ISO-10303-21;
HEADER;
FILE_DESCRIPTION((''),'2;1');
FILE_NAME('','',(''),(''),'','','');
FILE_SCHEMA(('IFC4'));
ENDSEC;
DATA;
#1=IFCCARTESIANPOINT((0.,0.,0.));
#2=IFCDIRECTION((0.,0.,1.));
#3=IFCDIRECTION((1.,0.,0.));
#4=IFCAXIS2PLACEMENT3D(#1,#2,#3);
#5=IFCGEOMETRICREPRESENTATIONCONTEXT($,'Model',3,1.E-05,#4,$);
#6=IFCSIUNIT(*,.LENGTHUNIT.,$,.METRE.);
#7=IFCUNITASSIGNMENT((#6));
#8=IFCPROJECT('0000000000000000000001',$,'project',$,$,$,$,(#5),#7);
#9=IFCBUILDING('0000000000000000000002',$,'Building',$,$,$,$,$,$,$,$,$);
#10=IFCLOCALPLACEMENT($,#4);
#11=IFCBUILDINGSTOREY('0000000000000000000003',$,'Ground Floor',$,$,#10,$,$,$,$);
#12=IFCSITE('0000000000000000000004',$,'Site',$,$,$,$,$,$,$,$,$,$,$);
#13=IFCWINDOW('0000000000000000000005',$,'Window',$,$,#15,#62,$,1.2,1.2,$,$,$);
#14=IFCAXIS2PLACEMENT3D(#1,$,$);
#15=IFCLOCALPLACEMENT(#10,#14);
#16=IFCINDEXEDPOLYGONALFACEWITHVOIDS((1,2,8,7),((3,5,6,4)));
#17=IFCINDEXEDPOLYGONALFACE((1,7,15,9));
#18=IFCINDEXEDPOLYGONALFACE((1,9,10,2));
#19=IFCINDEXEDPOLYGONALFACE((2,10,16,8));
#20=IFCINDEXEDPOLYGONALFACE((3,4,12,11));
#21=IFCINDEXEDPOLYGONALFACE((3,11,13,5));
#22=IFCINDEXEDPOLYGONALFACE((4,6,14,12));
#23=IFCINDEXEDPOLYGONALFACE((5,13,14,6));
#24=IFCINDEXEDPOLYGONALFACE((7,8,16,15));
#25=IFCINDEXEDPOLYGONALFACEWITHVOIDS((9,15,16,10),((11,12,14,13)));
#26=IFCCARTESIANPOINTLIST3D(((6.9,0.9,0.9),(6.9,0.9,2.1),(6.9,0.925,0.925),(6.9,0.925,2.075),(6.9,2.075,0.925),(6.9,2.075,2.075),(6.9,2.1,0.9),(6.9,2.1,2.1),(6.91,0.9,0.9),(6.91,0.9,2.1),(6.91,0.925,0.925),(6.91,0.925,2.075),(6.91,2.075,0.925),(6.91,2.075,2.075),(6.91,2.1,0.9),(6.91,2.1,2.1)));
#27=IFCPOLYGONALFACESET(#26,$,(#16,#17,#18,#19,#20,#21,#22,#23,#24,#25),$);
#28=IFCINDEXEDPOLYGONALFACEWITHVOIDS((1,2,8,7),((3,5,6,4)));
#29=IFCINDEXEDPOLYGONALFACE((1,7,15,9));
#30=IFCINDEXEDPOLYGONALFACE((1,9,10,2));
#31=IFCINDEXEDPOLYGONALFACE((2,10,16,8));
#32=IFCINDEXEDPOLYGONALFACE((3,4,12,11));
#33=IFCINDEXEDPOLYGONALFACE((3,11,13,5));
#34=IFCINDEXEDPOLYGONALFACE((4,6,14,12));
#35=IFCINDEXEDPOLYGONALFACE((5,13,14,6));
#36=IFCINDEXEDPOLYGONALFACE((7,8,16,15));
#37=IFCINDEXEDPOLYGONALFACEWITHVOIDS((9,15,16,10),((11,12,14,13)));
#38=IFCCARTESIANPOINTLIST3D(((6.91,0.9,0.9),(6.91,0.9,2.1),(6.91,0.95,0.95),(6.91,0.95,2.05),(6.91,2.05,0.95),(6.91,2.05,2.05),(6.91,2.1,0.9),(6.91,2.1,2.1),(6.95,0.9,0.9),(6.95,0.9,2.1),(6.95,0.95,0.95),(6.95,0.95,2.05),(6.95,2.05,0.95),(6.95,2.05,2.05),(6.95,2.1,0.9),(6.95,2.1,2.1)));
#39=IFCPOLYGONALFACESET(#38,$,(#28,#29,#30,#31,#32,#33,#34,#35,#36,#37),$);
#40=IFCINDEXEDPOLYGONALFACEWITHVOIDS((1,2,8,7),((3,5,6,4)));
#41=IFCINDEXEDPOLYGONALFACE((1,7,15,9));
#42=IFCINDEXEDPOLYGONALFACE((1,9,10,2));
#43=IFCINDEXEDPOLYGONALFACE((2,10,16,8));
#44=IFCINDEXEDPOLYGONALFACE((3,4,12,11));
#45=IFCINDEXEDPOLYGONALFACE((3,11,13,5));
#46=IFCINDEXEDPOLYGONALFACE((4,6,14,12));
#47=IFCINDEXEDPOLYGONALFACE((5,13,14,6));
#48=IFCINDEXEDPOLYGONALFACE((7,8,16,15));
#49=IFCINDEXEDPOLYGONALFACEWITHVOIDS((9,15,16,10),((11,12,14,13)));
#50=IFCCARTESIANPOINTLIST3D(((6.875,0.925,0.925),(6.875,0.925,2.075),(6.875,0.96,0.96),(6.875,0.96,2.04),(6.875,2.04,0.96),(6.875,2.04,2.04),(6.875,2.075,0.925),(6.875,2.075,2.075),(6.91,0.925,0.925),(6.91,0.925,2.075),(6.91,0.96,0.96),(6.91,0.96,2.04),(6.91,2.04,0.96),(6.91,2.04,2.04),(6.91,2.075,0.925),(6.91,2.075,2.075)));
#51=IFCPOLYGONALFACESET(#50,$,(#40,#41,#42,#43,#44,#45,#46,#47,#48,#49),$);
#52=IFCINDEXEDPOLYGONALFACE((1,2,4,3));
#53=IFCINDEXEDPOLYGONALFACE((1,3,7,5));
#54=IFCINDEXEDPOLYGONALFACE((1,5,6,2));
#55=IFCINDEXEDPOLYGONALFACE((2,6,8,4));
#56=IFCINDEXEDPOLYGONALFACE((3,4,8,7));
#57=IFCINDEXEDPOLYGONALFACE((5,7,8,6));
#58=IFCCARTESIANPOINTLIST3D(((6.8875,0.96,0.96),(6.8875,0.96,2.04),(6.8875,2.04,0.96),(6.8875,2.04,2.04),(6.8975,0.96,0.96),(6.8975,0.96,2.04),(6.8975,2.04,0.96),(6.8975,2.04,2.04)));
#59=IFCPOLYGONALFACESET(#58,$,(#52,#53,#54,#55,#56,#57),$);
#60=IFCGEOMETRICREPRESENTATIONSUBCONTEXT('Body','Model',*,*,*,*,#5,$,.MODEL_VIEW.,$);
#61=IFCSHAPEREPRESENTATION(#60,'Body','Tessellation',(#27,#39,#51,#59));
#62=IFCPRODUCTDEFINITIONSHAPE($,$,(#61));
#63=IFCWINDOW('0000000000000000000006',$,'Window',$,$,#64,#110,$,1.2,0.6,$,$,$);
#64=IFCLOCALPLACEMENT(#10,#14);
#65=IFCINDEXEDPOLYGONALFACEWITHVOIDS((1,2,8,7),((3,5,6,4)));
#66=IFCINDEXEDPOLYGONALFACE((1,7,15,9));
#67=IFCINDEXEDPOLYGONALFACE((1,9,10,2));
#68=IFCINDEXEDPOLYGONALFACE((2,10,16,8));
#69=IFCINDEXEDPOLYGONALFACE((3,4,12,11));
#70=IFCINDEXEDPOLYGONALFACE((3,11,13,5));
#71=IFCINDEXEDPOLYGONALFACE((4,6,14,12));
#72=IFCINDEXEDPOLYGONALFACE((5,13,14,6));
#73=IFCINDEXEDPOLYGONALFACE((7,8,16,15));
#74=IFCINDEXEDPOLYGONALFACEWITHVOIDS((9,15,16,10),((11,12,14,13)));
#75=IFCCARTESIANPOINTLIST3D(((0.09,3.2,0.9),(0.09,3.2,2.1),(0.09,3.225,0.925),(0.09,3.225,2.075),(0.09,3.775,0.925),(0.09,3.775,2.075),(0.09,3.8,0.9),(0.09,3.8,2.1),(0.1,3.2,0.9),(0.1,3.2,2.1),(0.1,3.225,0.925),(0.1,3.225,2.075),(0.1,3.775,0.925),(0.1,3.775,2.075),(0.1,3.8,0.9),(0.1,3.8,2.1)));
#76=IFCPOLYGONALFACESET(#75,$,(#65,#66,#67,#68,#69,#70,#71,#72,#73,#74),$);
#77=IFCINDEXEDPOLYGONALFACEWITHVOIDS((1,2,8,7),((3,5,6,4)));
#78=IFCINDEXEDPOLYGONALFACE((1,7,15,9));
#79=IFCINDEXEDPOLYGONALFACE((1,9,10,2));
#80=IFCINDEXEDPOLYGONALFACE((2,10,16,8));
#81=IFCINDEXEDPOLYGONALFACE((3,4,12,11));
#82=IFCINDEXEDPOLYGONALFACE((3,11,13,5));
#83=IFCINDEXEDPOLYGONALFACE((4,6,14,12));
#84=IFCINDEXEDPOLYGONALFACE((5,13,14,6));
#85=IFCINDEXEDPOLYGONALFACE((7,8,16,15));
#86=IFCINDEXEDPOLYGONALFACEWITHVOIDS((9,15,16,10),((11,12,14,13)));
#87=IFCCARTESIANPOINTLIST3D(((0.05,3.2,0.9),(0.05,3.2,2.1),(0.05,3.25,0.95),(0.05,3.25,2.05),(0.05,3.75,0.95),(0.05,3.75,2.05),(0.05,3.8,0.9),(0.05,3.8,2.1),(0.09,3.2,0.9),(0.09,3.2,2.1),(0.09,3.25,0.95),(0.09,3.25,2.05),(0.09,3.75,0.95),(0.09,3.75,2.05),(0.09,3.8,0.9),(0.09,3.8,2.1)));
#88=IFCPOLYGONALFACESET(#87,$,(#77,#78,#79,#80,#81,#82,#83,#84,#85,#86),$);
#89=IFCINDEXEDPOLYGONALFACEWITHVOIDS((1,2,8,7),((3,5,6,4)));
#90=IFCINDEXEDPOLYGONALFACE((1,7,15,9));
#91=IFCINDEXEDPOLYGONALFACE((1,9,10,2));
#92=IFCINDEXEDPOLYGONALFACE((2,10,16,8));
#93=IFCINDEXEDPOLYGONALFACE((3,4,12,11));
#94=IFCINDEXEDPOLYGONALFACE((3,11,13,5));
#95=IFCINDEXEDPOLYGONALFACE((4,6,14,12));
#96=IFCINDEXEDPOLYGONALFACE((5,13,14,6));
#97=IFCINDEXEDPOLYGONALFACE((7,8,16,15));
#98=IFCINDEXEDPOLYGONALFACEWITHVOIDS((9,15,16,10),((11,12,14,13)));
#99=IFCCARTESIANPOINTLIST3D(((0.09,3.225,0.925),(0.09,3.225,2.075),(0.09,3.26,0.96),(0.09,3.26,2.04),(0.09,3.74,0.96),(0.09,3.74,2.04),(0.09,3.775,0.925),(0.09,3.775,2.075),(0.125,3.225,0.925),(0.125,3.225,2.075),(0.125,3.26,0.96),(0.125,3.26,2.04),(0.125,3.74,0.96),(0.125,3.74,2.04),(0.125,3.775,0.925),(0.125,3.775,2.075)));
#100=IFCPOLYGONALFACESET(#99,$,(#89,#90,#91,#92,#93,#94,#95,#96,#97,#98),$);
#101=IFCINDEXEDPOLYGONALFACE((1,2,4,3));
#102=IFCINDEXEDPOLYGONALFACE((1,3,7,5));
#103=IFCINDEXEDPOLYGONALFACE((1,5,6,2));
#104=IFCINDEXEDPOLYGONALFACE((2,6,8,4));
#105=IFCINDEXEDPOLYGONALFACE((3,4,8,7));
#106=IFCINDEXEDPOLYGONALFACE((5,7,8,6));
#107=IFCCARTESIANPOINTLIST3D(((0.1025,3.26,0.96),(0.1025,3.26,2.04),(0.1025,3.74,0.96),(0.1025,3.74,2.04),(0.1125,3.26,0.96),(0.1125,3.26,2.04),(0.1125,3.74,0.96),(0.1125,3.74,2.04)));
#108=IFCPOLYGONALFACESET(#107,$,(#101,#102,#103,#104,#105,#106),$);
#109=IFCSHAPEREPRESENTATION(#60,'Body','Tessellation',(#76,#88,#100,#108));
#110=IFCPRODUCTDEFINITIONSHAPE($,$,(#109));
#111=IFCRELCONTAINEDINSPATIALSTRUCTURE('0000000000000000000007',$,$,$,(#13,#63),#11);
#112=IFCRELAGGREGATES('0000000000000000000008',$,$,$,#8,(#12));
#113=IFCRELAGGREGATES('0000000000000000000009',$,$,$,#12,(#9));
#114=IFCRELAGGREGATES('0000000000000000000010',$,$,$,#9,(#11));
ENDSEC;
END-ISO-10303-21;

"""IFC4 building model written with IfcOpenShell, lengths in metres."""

from ifc_helpers import new_model, si_unit, frame, origin_with_axes, place, context, subcontext, project, spatial, line, indexed_curve, outline, extrude, element, save


model = new_model("IFC4")

# Units and contexts
model_context = context("Model", 3, precision=1e-05, world=origin_with_axes())
body_context = subcontext(model_context, "Body", "Model", "MODEL_VIEW")
ifc_project = project(units=[si_unit("LENGTHUNIT", "METRE")], contexts=[model_context])

# Site, building, storey
site = spatial("IfcSite", under=ifc_project, Name="Site")
building = spatial("IfcBuilding", under=site, Name="Building")
storey_placement = place(None, origin_with_axes())
storey = spatial("IfcBuildingStorey", under=building, at=storey_placement, Name="Ground Floor")

# Windows
window_1_placement = place(storey_placement, frame((7.0, 0.9, 0.9), z_axis=(0.0, 0.0, 1.0), x_axis=(0.0, 1.0, 0.0)))
element("IfcWindow", 1, at=window_1_placement, inside=storey, Name="Window", OverallHeight=1.2, OverallWidth=1.2, context=body_context, shape_type="SweptSolid", body=[
    extrude(outline(indexed_curve([(0.0, 0.0), (1.2, 0.0), (1.2, 1.2), (0.0, 1.2)], segments=[line(1, 2, 3, 4, 1)]), holes=[indexed_curve([(0.025, 0.025), (1.175, 0.025), (1.175, 1.175), (0.025, 1.175)], segments=[line(1, 2, 3, 4, 1)])]), frame((0.0, 0.09, 0.0), z_axis=(0.0, -1.0, 0.0), x_axis=(1.0, 0.0, 0.0)), (0.0, 0.0, -1.0), 0.01),
    extrude(outline(indexed_curve([(0.0, 0.0), (1.2, 0.0), (1.2, 1.2), (0.0, 1.2)], segments=[line(1, 2, 3, 4, 1)]), holes=[indexed_curve([(0.05, 0.05), (1.15, 0.05), (1.15, 1.15), (0.05, 1.15)], segments=[line(1, 2, 3, 4, 1)])]), frame((0.0, 0.05, 0.0), z_axis=(0.0, -1.0, 0.0), x_axis=(1.0, 0.0, 0.0)), (0.0, 0.0, -1.0), 0.04),
    extrude(outline(indexed_curve([(0.0, 0.0), (1.15, 0.0), (1.15, 1.15), (0.0, 1.15)], segments=[line(1, 2, 3, 4, 1)]), holes=[indexed_curve([(0.035, 0.035), (1.115, 0.035), (1.115, 1.115), (0.035, 1.115)], segments=[line(1, 2, 3, 4, 1)])]), frame((0.025, 0.09, 0.025), z_axis=(0.0, -1.0, 0.0), x_axis=(1.0, 0.0, 0.0)), (0.0, 0.0, -1.0), 0.035),
    extrude(outline(indexed_curve([(0.035, 0.035), (1.115, 0.035), (1.115, 1.115), (0.035, 1.115)], segments=[line(1, 2, 3, 4, 1)])), frame((0.025, 0.1025, 0.025), z_axis=(0.0, -1.0, 0.0), x_axis=(1.0, 0.0, 0.0)), (0.0, 0.0, -1.0), 0.01),
])
window_2_placement = place(storey_placement, frame((0.0, 3.8, 0.9), z_axis=(0.0, 0.0, 1.0), x_axis=(0.0, -1.0, 0.0)))
element("IfcWindow", 2, at=window_2_placement, inside=storey, Name="Window", OverallHeight=1.2, OverallWidth=0.6, context=body_context, shape_type="SweptSolid", body=[
    extrude(outline(indexed_curve([(0.0, 0.0), (0.6, 0.0), (0.6, 1.2), (0.0, 1.2)], segments=[line(1, 2, 3, 4, 1)]), holes=[indexed_curve([(0.025, 0.025), (0.575, 0.025), (0.575, 1.175), (0.025, 1.175)], segments=[line(1, 2, 3, 4, 1)])]), frame((0.0, 0.09, 0.0), z_axis=(0.0, -1.0, 0.0), x_axis=(1.0, 0.0, 0.0)), (0.0, 0.0, -1.0), 0.01),
    extrude(outline(indexed_curve([(0.0, 0.0), (0.6, 0.0), (0.6, 1.2), (0.0, 1.2)], segments=[line(1, 2, 3, 4, 1)]), holes=[indexed_curve([(0.05, 0.05), (0.55, 0.05), (0.55, 1.15), (0.05, 1.15)], segments=[line(1, 2, 3, 4, 1)])]), frame((0.0, 0.05, 0.0), z_axis=(0.0, -1.0, 0.0), x_axis=(1.0, 0.0, 0.0)), (0.0, 0.0, -1.0), 0.04),
    extrude(outline(indexed_curve([(0.0, 0.0), (0.55, 0.0), (0.55, 1.15), (0.0, 1.15)], segments=[line(1, 2, 3, 4, 1)]), holes=[indexed_curve([(0.035, 0.035), (0.515, 0.035), (0.515, 1.115), (0.035, 1.115)], segments=[line(1, 2, 3, 4, 1)])]), frame((0.025, 0.09, 0.025), z_axis=(0.0, -1.0, 0.0), x_axis=(1.0, 0.0, 0.0)), (0.0, 0.0, -1.0), 0.035),
    extrude(outline(indexed_curve([(0.035, 0.035), (0.515, 0.035), (0.515, 1.115), (0.035, 1.115)], segments=[line(1, 2, 3, 4, 1)])), frame((0.025, 0.1025, 0.025), z_axis=(0.0, -1.0, 0.0), x_axis=(1.0, 0.0, 0.0)), (0.0, 0.0, -1.0), 0.01),
])

save(model, "model.ifc")
